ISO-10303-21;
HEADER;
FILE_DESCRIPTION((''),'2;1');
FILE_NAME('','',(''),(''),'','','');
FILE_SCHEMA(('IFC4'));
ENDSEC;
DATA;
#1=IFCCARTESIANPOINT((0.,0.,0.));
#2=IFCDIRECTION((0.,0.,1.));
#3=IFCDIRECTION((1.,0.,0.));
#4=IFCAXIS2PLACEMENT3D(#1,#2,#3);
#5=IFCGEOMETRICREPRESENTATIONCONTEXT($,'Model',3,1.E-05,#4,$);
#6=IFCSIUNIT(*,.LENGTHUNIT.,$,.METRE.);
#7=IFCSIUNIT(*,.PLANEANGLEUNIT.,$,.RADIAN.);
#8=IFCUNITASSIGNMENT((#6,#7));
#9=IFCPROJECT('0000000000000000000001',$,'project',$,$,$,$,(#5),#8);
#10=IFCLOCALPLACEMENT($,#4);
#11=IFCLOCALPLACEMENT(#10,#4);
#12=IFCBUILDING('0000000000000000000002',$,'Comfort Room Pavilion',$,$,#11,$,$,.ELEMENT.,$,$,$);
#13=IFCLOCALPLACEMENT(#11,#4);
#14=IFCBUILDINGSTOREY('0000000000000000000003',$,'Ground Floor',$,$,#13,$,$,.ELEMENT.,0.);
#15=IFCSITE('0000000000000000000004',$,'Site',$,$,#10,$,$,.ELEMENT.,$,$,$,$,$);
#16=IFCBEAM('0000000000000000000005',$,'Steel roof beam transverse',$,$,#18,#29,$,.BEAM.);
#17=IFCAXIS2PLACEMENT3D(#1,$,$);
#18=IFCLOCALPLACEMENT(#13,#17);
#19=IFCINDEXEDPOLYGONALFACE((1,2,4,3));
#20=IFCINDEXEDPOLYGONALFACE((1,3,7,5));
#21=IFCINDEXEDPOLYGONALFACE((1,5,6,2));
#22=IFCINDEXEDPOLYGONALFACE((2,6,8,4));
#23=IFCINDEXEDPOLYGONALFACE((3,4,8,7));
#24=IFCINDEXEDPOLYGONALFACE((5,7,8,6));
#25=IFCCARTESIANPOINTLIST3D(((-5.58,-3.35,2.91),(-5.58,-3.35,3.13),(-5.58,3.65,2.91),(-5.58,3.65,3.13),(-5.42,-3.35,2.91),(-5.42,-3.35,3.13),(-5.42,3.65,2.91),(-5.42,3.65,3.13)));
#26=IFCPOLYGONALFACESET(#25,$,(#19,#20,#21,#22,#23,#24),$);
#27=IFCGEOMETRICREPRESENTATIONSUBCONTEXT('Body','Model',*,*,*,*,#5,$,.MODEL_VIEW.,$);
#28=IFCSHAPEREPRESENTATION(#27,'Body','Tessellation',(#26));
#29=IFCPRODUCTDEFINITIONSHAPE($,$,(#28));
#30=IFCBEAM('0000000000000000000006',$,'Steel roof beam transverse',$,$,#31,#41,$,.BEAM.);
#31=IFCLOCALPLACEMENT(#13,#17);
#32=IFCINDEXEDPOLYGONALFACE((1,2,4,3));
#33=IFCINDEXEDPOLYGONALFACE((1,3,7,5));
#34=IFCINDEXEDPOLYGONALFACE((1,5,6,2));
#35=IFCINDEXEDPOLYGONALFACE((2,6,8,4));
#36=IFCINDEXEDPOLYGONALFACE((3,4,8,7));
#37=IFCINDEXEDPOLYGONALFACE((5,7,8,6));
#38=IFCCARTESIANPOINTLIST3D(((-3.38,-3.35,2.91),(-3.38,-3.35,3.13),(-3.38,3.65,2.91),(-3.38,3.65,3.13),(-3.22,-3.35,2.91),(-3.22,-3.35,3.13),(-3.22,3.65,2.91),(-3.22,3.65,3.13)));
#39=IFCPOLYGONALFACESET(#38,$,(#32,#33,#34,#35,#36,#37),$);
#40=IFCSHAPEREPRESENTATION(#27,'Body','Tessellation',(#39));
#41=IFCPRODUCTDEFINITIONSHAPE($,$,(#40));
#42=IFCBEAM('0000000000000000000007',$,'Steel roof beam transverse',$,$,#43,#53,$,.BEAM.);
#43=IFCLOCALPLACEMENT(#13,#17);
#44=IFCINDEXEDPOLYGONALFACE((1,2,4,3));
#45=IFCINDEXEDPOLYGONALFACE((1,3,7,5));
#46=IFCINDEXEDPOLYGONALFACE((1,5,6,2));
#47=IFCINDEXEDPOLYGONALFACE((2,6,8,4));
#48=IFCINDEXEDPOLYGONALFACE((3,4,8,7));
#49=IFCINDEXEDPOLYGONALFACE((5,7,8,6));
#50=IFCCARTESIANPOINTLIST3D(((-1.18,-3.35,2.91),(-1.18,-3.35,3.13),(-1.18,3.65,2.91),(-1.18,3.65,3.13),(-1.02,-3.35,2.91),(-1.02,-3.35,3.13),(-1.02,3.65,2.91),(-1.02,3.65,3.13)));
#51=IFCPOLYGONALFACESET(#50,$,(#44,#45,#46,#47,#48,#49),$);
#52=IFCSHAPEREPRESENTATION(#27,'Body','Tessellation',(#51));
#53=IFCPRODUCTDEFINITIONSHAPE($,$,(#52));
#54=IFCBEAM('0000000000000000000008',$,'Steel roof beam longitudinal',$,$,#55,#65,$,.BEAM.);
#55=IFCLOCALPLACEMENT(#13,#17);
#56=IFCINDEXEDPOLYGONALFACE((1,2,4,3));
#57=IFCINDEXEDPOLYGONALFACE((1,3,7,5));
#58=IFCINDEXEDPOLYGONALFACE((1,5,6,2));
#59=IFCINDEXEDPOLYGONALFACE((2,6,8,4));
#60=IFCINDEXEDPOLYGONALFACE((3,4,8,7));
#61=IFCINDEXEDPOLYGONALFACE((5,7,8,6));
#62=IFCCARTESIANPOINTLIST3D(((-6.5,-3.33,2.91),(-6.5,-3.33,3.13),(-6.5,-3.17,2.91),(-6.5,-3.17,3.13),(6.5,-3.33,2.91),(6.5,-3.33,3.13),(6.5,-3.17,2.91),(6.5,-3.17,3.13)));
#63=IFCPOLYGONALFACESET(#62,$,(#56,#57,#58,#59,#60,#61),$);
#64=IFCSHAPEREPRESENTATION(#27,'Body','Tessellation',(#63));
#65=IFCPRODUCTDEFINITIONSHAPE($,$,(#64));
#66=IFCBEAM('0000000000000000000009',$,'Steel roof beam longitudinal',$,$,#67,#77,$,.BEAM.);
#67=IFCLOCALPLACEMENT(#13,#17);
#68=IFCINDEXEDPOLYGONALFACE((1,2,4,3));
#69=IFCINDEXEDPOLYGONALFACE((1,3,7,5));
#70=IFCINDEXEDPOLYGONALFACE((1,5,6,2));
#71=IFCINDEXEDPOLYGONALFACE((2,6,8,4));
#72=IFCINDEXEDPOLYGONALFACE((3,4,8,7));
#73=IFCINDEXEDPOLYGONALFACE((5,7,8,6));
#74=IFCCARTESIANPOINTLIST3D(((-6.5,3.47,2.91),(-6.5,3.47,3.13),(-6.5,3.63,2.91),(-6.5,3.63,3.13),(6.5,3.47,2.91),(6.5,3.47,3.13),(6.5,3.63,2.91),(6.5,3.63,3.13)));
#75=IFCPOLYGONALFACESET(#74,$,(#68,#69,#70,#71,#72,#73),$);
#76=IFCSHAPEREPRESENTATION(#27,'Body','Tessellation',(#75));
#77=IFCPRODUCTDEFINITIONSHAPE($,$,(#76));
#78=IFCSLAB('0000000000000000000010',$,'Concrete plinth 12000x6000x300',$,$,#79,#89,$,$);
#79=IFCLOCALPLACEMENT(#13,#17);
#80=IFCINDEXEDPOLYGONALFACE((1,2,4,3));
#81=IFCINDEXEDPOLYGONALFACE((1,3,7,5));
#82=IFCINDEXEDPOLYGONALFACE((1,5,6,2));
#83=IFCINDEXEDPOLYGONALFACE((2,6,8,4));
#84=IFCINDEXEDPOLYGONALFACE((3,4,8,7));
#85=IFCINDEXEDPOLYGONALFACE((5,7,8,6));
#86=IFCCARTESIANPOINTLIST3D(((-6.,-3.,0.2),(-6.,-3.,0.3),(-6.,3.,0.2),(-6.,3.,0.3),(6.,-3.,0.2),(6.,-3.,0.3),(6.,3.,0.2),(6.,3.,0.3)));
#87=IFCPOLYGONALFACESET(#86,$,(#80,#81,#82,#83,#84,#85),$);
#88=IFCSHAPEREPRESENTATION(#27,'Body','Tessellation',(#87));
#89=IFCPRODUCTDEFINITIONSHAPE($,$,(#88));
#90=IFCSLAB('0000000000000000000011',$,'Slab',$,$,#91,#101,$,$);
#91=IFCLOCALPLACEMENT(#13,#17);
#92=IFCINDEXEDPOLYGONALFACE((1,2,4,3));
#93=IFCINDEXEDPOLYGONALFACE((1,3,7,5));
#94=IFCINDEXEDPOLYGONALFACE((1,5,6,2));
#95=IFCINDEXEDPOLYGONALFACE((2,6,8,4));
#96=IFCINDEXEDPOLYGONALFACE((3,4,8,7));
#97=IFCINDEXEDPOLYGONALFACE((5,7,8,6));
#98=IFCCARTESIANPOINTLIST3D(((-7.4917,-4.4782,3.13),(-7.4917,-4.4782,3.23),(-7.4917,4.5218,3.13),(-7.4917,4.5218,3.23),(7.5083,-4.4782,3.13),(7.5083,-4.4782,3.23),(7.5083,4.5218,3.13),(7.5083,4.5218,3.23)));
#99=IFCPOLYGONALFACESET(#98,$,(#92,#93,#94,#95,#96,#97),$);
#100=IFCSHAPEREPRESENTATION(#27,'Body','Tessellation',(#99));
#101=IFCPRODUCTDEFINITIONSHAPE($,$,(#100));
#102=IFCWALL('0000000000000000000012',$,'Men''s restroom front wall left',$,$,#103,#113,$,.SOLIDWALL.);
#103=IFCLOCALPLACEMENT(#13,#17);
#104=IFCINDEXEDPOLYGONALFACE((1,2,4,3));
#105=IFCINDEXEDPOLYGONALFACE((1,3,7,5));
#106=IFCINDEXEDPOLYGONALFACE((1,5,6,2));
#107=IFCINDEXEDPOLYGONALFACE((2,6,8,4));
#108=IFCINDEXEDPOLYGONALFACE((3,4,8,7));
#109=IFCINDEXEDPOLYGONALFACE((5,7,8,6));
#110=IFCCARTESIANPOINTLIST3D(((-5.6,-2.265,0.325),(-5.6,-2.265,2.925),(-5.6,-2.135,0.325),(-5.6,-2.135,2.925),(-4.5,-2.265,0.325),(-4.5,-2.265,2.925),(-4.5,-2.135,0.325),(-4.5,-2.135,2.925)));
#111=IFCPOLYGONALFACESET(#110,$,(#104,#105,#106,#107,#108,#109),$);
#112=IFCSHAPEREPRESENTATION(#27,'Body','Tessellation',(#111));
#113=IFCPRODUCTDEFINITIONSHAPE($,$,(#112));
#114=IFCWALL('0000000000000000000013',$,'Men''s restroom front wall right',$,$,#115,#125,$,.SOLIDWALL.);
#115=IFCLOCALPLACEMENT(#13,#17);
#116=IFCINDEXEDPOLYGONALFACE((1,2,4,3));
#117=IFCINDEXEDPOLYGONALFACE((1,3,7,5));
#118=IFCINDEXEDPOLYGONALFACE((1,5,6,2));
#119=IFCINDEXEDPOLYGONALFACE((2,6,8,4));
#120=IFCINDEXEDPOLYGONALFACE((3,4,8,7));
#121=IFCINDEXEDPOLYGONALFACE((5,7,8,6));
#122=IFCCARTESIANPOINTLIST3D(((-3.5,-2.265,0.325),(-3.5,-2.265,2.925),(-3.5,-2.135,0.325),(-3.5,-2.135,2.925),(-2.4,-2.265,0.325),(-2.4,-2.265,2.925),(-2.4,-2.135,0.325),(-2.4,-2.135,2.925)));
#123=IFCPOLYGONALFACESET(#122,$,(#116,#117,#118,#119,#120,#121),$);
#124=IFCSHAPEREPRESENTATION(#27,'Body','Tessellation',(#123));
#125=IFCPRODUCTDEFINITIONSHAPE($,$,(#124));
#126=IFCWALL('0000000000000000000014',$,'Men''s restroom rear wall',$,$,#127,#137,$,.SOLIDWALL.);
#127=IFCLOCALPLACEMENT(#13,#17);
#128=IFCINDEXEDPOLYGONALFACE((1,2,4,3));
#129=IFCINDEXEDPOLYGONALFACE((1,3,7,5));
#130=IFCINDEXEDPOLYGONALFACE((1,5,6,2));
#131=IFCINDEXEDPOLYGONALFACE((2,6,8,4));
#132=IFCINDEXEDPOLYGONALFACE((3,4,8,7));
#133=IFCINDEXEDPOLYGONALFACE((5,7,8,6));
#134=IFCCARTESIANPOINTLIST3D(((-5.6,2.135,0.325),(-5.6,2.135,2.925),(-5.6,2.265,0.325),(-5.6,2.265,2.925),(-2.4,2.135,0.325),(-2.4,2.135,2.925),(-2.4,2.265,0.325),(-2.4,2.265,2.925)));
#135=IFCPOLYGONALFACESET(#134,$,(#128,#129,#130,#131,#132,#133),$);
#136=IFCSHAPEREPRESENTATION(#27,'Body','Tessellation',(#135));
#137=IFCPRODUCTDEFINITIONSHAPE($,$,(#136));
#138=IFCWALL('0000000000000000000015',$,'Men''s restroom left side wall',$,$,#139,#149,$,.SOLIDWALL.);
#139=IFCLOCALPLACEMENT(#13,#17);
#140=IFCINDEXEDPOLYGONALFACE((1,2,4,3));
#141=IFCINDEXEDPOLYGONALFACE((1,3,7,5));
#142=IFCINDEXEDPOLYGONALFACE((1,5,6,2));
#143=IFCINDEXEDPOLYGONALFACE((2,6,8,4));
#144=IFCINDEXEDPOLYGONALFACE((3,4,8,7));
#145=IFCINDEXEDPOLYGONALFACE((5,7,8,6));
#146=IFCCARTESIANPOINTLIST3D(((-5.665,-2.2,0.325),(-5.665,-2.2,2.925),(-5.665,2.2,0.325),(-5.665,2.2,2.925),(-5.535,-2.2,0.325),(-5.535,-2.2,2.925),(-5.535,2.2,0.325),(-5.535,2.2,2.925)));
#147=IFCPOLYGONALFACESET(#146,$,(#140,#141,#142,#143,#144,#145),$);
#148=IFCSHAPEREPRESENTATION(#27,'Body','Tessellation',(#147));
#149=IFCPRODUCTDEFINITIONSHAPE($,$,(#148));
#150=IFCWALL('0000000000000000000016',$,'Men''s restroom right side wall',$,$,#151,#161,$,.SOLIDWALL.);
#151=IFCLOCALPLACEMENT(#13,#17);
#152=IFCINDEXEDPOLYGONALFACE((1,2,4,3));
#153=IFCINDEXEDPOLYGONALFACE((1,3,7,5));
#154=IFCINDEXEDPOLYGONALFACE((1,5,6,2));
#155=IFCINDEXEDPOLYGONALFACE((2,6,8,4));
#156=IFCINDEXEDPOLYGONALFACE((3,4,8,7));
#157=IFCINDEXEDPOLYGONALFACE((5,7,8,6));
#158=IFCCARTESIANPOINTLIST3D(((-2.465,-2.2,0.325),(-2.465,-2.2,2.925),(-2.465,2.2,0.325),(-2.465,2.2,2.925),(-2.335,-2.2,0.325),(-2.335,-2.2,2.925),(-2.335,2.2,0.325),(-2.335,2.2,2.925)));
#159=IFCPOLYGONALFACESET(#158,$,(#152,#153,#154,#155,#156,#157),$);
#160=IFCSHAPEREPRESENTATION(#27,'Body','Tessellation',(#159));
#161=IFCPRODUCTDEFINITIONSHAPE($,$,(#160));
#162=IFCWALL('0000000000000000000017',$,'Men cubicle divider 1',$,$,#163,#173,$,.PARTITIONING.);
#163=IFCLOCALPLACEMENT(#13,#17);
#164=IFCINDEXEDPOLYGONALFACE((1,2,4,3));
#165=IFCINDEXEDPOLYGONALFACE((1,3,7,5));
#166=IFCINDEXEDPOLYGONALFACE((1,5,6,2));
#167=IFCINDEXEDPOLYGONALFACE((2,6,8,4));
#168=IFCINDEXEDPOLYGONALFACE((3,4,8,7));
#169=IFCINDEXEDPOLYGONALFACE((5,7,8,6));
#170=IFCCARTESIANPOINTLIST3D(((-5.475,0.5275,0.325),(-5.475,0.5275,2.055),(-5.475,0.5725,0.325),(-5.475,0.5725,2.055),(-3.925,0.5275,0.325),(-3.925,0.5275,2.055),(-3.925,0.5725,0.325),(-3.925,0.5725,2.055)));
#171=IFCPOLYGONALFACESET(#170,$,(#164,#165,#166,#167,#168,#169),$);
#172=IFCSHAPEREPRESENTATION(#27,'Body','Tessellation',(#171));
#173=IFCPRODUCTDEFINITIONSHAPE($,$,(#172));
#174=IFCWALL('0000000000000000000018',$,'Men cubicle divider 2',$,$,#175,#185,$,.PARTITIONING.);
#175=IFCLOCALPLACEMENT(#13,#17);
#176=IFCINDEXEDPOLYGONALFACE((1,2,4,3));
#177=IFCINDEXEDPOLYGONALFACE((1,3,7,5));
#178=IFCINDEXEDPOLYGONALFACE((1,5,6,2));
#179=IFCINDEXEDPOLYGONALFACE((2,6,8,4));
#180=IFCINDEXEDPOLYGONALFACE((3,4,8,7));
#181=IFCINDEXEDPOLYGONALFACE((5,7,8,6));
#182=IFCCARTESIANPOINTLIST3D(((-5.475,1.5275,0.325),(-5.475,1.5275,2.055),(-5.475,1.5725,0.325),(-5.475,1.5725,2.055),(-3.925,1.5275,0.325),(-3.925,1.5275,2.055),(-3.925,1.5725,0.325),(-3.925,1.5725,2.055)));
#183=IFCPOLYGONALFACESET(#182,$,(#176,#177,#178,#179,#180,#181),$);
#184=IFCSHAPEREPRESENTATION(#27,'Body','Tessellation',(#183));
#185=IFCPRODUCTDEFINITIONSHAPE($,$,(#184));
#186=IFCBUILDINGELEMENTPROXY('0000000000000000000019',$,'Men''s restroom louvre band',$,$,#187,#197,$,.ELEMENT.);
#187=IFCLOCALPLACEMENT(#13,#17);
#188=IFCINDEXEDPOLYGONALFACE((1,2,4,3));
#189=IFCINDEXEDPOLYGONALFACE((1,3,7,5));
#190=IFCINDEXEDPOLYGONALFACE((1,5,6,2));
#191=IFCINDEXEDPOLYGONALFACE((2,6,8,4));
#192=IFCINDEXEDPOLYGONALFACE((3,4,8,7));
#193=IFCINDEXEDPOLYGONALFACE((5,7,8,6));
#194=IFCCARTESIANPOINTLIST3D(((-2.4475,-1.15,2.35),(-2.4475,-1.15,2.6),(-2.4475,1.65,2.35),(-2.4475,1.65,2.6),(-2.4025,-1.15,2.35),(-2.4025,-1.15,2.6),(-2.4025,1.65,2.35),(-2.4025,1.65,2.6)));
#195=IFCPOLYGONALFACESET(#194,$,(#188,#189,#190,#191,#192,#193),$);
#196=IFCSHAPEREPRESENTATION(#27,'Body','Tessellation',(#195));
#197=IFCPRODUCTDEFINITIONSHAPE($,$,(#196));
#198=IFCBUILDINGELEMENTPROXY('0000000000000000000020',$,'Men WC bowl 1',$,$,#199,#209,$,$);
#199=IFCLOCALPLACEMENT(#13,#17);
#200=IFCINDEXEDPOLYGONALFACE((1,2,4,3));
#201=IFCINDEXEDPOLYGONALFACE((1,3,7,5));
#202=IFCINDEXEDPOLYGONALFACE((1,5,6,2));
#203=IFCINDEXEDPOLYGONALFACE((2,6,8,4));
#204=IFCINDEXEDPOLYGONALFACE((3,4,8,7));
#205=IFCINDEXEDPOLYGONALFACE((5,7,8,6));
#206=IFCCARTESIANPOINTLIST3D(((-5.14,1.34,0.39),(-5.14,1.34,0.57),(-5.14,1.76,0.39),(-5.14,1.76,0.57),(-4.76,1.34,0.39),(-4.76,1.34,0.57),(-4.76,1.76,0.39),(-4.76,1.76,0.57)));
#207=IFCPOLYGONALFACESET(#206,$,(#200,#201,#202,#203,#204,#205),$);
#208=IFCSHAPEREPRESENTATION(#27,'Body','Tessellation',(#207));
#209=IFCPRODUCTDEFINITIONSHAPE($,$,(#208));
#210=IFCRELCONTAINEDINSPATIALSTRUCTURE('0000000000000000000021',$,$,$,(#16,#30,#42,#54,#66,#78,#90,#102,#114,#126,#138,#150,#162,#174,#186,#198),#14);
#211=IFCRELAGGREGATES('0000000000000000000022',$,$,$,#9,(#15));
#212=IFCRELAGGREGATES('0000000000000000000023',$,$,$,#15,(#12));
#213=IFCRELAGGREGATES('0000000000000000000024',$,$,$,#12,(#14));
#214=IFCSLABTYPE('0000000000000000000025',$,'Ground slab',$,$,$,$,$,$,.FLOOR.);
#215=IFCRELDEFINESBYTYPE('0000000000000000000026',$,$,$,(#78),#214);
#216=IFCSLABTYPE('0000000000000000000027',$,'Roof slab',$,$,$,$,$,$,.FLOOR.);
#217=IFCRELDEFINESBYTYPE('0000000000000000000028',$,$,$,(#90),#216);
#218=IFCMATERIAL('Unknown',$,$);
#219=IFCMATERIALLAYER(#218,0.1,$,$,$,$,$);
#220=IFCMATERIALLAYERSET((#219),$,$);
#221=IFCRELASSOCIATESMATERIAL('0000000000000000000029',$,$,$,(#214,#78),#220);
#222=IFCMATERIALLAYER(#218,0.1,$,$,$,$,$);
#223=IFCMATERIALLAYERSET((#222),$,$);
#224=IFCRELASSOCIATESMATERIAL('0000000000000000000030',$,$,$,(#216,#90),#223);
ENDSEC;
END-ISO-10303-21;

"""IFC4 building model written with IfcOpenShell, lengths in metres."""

from ifc_helpers import new_model, si_unit, frame, origin_with_axes, origin_2d, place, context, subcontext, project, spatial, indexed_curve, rectangle, outline, extrude, material, layer, layer_set, layer_usage, type_object, element, save


model = new_model("IFC4")

# Units and contexts
model_context = context("Model", 3, precision=1e-05, world=origin_with_axes())
body_context = subcontext(model_context, "Body", "Model", "MODEL_VIEW")
ifc_project = project(units=[si_unit("LENGTHUNIT", "METRE"), si_unit("PLANEANGLEUNIT", "RADIAN")], contexts=[model_context])

# Site, building, storey
site_placement = place(None, origin_with_axes())
site = spatial("IfcSite", under=ifc_project, at=site_placement, Name="Site", CompositionType="ELEMENT")
building_placement = place(site_placement, origin_with_axes())
building = spatial("IfcBuilding", under=site, at=building_placement, Name="Comfort Room Pavilion", CompositionType="ELEMENT")
storey_placement = place(building_placement, origin_with_axes())
storey = spatial("IfcBuildingStorey", under=building, at=storey_placement, Name="Ground Floor", CompositionType="ELEMENT", Elevation=0.0)

# Beams
for number, where, z_axis, x_axis, name in (
    (1, (-5.5, 0.15, 2.91), (0.0, 0.0, 1.0), (1.0, 0.0, 0.0), "Steel roof beam transverse"),
    (2, (-3.3, 0.15, 2.91), (0.0, 0.0, 1.0), (1.0, 0.0, 0.0), "Steel roof beam transverse"),
    (3, (-1.1, 0.15, 2.91), (0.0, 0.0, 1.0), (1.0, 0.0, 0.0), "Steel roof beam transverse"),
):
    element("IfcBeam", number, at=place(storey_placement, frame(where, z_axis=z_axis, x_axis=x_axis)), inside=storey, Name=name, PredefinedType="BEAM", context=body_context, shape_type="SweptSolid", body=[
        extrude(rectangle(XDim=0.16, YDim=7.0, at=origin_2d()), origin_with_axes(), (0.0, 0.0, 1.0), 0.22),
    ])
for number, where, z_axis, x_axis, name in (
    (4, (0.0, -3.25, 2.91), (0.0, 0.0, 1.0), (1.0, 0.0, 0.0), "Steel roof beam longitudinal"),
    (5, (0.0, 3.55, 2.91), (0.0, 0.0, 1.0), (1.0, 0.0, 0.0), "Steel roof beam longitudinal"),
):
    element("IfcBeam", number, at=place(storey_placement, frame(where, z_axis=z_axis, x_axis=x_axis)), inside=storey, Name=name, PredefinedType="BEAM", context=body_context, shape_type="SweptSolid", body=[
        extrude(rectangle(XDim=13.0, YDim=0.16, at=origin_2d()), origin_with_axes(), (0.0, 0.0, 1.0), 0.22),
    ])

# Slabs
ifc_material = material(Name="Unknown")
ifc_layer_1 = layer(ifc_material, 0.1)
ifc_layer_set_1 = layer_set([ifc_layer_1])
ifc_layer_usage_1 = layer_usage(ifc_layer_set_1, "AXIS3", "POSITIVE", 0.0)
slab_type_1 = type_object("IfcSlabType", Name="Ground slab", PredefinedType="FLOOR", material=ifc_layer_set_1)
slab_1_placement = place(storey_placement, frame((0.0, 0.0, 0.2), z_axis=(0.0, 0.0, 1.0), x_axis=(1.0, 0.0, 0.0)))
element("IfcSlab", 6, at=slab_1_placement, inside=storey, type_object=slab_type_1, material=ifc_layer_usage_1, Name="Concrete plinth 12000x6000x300", context=body_context, shape_type="SweptSolid", body=[
    extrude(rectangle(XDim=12.0, YDim=6.0, at=origin_2d()), origin_with_axes(), (0.0, 0.0, 1.0), 0.1),
])
ifc_layer_2 = layer(ifc_material, 0.1)
ifc_layer_set_2 = layer_set([ifc_layer_2])
ifc_layer_usage_2 = layer_usage(ifc_layer_set_2, "AXIS3", "POSITIVE", -0.1)
slab_type_2 = type_object("IfcSlabType", Name="Roof slab", PredefinedType="FLOOR", material=ifc_layer_set_2)
slab_2_placement = place(storey_placement, frame((-7.4917, 4.5218, 3.23), z_axis=(0.0, 0.0, 1.0), x_axis=(1.0, 0.0, 0.0)))
element("IfcSlab", 7, at=slab_2_placement, inside=storey, type_object=slab_type_2, material=ifc_layer_usage_2, Name="Slab", context=body_context, shape_type="SweptSolid", body=[
    extrude(outline(indexed_curve([(0.0, 0.0), (0.0, -9.0), (15.0, -9.0), (15.0, 0.0), (0.0, 0.0)])), frame((0.0, 0.0, -0.1), z_axis=(0.0, 0.0, 1.0), x_axis=(1.0, 0.0, 0.0)), (0.0, 0.0, 1.0), 0.1),
])

# Walls
for number, where, z_axis, x_axis, name in (
    (8, (-5.05, -2.2, 0.325), (0.0, 0.0, 1.0), (1.0, 0.0, 0.0), "Men's restroom front wall left"),
    (9, (-2.95, -2.2, 0.325), (0.0, 0.0, 1.0), (1.0, 0.0, 0.0), "Men's restroom front wall right"),
):
    element("IfcWall", number, at=place(storey_placement, frame(where, z_axis=z_axis, x_axis=x_axis)), inside=storey, Name=name, PredefinedType="SOLIDWALL", context=body_context, shape_type="SweptSolid", body=[
        extrude(rectangle(XDim=1.1, YDim=0.13, at=origin_2d()), origin_with_axes(), (0.0, 0.0, 1.0), 2.6),
    ])
wall_placement = place(storey_placement, frame((-4.0, 2.2, 0.325), z_axis=(0.0, 0.0, 1.0), x_axis=(1.0, 0.0, 0.0)))
element("IfcWall", 10, at=wall_placement, inside=storey, Name="Men's restroom rear wall", PredefinedType="SOLIDWALL", context=body_context, shape_type="SweptSolid", body=[
    extrude(rectangle(XDim=3.2, YDim=0.13, at=origin_2d()), origin_with_axes(), (0.0, 0.0, 1.0), 2.6),
])
for number, where, z_axis, x_axis, name in (
    (11, (-5.6, 0.0, 0.325), (0.0, 0.0, 1.0), (1.0, 0.0, 0.0), "Men's restroom left side wall"),
    (12, (-2.4, 0.0, 0.325), (0.0, 0.0, 1.0), (1.0, 0.0, 0.0), "Men's restroom right side wall"),
):
    element("IfcWall", number, at=place(storey_placement, frame(where, z_axis=z_axis, x_axis=x_axis)), inside=storey, Name=name, PredefinedType="SOLIDWALL", context=body_context, shape_type="SweptSolid", body=[
        extrude(rectangle(XDim=0.13, YDim=4.4, at=origin_2d()), origin_with_axes(), (0.0, 0.0, 1.0), 2.6),
    ])
for number, where, z_axis, x_axis, name in (
    (13, (-4.7, 0.55, 0.325), (0.0, 0.0, 1.0), (1.0, 0.0, 0.0), "Men cubicle divider 1"),
    (14, (-4.7, 1.55, 0.325), (0.0, 0.0, 1.0), (1.0, 0.0, 0.0), "Men cubicle divider 2"),
):
    element("IfcWall", number, at=place(storey_placement, frame(where, z_axis=z_axis, x_axis=x_axis)), inside=storey, Name=name, PredefinedType="PARTITIONING", context=body_context, shape_type="SweptSolid", body=[
        extrude(rectangle(XDim=1.55, YDim=0.045, at=origin_2d()), origin_with_axes(), (0.0, 0.0, 1.0), 1.73),
    ])

# Building element proxies
proxy_1_placement = place(storey_placement, frame((-2.425, 0.25, 2.35), z_axis=(0.0, 0.0, 1.0), x_axis=(1.0, 0.0, 0.0)))
element("IfcBuildingElementProxy", 15, at=proxy_1_placement, inside=storey, Name="Men's restroom louvre band", PredefinedType="ELEMENT", context=body_context, shape_type="SweptSolid", body=[
    extrude(rectangle(XDim=0.045, YDim=2.8, at=origin_2d()), origin_with_axes(), (0.0, 0.0, 1.0), 0.25),
])
proxy_2_placement = place(storey_placement, frame((-4.95, 1.55, 0.39), z_axis=(0.0, 0.0, 1.0), x_axis=(1.0, 0.0, 0.0)))
element("IfcBuildingElementProxy", 16, at=proxy_2_placement, inside=storey, Name="Men WC bowl 1", context=body_context, shape_type="SweptSolid", body=[
    extrude(rectangle(XDim=0.38, YDim=0.42, at=origin_2d()), origin_with_axes(), (0.0, 0.0, 1.0), 0.18),
])

save(model, "model.ifc")
